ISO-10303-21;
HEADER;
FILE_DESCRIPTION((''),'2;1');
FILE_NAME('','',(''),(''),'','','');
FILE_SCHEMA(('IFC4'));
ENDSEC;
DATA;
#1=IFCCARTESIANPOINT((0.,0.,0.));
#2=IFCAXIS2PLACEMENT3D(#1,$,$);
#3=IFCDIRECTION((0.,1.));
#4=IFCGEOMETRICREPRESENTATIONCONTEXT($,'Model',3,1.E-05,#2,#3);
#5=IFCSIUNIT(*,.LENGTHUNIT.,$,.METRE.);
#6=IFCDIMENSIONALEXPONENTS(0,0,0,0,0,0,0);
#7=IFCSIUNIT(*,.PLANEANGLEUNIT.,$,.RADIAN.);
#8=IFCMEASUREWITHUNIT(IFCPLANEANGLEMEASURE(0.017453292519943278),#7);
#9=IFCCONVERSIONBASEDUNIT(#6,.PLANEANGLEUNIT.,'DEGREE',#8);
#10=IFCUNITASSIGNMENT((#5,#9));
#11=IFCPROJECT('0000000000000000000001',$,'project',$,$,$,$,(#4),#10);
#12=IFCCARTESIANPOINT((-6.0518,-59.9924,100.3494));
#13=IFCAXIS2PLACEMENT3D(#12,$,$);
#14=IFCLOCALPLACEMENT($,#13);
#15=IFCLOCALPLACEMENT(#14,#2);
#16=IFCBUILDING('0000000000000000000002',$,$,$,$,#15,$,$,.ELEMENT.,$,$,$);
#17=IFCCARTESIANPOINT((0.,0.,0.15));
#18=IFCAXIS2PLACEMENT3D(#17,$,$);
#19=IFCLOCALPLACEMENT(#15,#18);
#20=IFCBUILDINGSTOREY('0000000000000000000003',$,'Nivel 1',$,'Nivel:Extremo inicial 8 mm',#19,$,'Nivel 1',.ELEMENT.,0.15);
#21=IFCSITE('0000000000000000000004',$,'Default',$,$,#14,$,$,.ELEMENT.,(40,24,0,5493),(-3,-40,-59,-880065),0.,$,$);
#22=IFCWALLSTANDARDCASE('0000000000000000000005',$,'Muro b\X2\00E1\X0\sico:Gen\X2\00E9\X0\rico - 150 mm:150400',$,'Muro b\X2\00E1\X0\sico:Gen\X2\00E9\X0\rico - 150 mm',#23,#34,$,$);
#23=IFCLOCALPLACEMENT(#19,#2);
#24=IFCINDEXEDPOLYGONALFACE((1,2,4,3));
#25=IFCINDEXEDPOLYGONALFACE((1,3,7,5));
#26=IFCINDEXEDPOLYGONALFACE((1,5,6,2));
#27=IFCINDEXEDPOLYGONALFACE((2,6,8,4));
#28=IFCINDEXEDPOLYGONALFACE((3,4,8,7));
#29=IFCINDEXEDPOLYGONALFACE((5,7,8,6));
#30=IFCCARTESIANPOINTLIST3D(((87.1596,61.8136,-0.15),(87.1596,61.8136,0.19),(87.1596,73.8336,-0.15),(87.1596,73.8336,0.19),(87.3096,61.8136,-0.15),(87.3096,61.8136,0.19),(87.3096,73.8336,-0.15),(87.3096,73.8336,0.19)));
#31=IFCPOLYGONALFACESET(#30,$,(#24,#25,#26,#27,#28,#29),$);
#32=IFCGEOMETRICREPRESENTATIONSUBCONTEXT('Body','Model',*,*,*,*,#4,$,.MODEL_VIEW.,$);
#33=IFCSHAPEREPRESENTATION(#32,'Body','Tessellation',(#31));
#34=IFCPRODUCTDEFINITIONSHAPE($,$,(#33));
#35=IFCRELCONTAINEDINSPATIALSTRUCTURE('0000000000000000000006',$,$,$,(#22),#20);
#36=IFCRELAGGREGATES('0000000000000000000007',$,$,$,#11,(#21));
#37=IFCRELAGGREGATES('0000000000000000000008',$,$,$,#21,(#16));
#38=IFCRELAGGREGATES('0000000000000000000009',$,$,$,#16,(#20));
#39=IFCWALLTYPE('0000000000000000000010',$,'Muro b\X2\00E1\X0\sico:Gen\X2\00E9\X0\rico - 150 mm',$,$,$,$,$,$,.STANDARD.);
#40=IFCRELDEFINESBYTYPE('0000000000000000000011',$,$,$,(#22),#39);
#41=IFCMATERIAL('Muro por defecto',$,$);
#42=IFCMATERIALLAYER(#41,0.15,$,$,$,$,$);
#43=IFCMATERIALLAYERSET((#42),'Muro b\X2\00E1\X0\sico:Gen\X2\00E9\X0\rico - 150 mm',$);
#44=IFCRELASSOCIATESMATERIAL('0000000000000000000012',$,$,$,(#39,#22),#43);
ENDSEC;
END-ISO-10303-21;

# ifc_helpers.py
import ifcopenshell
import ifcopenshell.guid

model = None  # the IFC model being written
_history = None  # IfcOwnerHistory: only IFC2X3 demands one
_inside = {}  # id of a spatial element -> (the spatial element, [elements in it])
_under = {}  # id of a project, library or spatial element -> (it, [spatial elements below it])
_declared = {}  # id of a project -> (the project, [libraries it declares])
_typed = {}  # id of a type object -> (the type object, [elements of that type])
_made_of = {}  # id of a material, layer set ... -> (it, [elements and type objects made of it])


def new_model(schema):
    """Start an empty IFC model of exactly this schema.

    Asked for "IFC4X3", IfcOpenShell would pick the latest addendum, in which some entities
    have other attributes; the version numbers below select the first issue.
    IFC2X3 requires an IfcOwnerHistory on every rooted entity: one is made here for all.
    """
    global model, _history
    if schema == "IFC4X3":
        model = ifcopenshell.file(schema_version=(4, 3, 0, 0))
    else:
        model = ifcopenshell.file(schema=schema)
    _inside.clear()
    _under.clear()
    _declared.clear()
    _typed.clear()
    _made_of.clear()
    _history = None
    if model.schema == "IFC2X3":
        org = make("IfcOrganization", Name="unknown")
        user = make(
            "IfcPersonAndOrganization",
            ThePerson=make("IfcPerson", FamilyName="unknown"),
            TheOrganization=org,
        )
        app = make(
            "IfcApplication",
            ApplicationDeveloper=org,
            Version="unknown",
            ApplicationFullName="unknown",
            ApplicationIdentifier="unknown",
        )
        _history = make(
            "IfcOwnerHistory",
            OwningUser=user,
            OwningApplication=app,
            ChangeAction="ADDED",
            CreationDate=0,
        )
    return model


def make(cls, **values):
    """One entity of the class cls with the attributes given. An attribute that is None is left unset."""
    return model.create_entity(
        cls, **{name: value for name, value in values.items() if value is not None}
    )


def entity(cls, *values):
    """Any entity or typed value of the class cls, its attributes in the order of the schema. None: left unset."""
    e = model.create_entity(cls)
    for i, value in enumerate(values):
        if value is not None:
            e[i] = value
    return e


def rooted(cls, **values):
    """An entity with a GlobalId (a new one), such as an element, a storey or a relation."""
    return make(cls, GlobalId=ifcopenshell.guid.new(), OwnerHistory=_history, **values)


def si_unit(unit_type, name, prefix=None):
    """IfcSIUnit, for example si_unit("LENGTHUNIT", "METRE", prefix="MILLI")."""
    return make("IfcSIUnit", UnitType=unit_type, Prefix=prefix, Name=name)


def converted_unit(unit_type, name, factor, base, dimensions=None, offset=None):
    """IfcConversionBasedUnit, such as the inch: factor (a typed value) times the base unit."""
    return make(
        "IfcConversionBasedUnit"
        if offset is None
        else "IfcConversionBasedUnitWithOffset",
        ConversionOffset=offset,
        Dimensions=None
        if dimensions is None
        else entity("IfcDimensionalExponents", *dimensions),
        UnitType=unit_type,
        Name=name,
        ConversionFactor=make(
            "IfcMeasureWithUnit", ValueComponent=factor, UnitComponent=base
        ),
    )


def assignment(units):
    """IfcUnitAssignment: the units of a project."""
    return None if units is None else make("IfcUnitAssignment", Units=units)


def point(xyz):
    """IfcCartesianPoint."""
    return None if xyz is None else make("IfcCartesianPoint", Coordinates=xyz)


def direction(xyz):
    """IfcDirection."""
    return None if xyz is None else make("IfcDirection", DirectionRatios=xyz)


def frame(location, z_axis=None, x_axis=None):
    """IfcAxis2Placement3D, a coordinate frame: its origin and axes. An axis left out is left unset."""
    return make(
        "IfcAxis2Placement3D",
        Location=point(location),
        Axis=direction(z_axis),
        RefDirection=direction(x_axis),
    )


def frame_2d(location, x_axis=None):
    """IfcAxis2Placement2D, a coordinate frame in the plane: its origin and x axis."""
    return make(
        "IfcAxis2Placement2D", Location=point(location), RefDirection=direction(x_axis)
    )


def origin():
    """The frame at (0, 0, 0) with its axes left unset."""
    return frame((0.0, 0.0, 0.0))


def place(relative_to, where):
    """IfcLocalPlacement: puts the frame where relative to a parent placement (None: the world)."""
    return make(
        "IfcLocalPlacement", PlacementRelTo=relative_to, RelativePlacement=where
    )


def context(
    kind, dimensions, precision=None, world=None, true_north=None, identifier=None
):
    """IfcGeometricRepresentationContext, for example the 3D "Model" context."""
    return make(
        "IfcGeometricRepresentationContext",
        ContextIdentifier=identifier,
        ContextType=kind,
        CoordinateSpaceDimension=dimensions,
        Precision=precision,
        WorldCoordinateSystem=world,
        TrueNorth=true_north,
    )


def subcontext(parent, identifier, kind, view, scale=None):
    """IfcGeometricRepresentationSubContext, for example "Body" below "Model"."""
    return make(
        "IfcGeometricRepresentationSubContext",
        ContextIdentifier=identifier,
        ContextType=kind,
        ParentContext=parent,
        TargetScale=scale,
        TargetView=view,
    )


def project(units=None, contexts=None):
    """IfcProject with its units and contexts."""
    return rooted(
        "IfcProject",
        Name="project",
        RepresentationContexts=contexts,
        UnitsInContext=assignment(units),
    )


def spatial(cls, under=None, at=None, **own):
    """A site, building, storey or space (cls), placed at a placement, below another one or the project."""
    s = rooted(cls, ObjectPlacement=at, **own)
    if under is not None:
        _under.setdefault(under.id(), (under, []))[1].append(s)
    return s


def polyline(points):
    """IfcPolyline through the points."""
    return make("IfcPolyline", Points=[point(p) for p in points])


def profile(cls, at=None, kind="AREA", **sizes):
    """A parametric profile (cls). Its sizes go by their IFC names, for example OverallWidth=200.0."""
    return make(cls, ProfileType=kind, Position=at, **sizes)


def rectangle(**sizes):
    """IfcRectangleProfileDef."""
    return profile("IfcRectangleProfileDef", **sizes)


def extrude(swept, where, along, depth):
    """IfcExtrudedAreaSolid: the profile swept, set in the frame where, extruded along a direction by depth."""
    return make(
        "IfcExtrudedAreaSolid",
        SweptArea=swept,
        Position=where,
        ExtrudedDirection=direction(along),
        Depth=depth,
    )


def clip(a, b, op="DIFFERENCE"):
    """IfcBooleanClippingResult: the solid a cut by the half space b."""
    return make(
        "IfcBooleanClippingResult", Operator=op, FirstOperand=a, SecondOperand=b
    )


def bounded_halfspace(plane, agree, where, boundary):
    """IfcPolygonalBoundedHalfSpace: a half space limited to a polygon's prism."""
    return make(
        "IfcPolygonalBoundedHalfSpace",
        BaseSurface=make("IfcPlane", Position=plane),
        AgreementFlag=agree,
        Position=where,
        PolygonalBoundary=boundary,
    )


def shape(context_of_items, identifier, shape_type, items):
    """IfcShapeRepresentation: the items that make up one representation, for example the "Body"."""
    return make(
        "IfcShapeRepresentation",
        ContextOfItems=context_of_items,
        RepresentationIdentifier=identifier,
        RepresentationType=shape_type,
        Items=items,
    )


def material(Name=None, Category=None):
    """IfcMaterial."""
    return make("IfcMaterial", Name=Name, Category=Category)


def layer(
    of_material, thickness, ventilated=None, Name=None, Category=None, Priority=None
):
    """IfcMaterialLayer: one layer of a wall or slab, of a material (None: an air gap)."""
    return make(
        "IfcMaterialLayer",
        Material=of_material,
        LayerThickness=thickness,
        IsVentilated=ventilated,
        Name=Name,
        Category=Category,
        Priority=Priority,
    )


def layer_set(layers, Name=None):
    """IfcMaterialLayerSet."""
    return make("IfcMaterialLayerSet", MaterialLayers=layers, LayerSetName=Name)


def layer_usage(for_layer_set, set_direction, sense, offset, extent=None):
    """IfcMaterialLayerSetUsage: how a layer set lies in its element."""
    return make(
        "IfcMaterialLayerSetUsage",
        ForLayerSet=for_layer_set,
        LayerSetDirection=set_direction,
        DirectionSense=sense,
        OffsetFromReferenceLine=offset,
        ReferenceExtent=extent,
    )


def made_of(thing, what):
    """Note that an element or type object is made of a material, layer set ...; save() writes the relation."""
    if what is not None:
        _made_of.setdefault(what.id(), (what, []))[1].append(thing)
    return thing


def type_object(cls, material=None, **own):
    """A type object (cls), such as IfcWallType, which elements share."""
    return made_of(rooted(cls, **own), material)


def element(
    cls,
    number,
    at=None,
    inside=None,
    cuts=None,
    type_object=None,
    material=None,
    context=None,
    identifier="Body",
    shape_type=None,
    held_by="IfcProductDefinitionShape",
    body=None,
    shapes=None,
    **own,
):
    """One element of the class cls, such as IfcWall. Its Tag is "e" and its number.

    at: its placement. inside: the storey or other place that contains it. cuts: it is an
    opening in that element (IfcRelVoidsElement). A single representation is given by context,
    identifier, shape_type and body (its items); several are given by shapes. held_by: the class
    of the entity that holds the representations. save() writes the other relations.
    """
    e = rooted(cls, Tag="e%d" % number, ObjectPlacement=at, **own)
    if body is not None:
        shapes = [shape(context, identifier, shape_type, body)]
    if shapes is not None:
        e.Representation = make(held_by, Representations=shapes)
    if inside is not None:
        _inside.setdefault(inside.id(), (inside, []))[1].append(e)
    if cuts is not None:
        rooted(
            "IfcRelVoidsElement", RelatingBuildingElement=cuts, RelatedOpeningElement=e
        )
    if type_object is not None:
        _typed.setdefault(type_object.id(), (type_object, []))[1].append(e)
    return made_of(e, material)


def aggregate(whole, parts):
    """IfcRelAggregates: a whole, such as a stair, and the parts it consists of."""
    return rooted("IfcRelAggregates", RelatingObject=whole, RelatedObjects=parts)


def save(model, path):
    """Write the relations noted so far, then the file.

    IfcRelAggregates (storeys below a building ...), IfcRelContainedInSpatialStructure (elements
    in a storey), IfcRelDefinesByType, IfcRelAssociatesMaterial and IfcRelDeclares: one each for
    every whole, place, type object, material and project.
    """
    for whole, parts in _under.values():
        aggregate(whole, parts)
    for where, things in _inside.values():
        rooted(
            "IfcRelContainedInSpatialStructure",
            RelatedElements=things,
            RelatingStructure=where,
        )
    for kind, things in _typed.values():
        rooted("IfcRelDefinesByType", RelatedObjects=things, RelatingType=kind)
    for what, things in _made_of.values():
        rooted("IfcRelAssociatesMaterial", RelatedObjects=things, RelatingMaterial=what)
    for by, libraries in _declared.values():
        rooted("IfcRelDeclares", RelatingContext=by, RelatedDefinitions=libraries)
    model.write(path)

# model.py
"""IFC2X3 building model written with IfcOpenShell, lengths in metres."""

from ifc_helpers import new_model, entity, si_unit, converted_unit, direction, frame, frame_2d, origin, place, context, subcontext, project, spatial, polyline, rectangle, extrude, clip, bounded_halfspace, material, layer, layer_set, layer_usage, type_object, element, save


model = new_model("IFC2X3")

# Units and contexts
model_context = context("Model", 3, precision=1e-05, world=origin(), true_north=direction((0.0, 1.0)))
body_context = subcontext(model_context, "Body", "Model", "MODEL_VIEW")
ifc_project = project(units=[si_unit("LENGTHUNIT", "METRE"), converted_unit("PLANEANGLEUNIT", "DEGREE", entity("IfcPlaneAngleMeasure", 0.017453292519943278), si_unit("PLANEANGLEUNIT", "RADIAN"), dimensions=[0, 0, 0, 0, 0, 0, 0])], contexts=[model_context])

# Site, building, storey
site_placement = place(None, frame((-6.0518, -59.9924, 100.3494)))
site = spatial("IfcSite", under=ifc_project, at=site_placement, Name="Default", CompositionType="ELEMENT", RefLatitude=(40, 24, 0, 5493), RefLongitude=(-3, -40, -59, -880065), RefElevation=0.0)
building_placement = place(site_placement, origin())
building = spatial("IfcBuilding", under=site, at=building_placement, CompositionType="ELEMENT")
storey_placement = place(building_placement, frame((0.0, 0.0, 0.15)))
storey = spatial("IfcBuildingStorey", under=building, at=storey_placement, Name="Nivel 1", ObjectType="Nivel:Extremo inicial 8 mm", LongName="Nivel 1", CompositionType="ELEMENT", Elevation=0.15)

# Wall
ifc_material_1 = material(Name="Muro por defecto")
ifc_layer = layer(ifc_material_1, 0.15)
ifc_layer_set = layer_set([ifc_layer], Name="Muro básico:Genérico - 150 mm")
ifc_layer_usage = layer_usage(ifc_layer_set, "AXIS2", "POSITIVE", -0.075)
wall_type = type_object("IfcWallType", Name="Muro básico:Genérico - 150 mm", PredefinedType="STANDARD", material=ifc_layer_set)
wall_placement = place(storey_placement, frame((87.2346, 73.8336, -0.15), z_axis=(0.0, 0.0, 1.0), x_axis=(0.0, -1.0, 0.0)))
element("IfcWallStandardCase", 1, at=wall_placement, inside=storey, type_object=wall_type, material=ifc_layer_usage, Name="Muro básico:Genérico - 150 mm:150400", ObjectType="Muro básico:Genérico - 150 mm", context=body_context, shape_type="Clipping", body=[
    clip(extrude(rectangle(XDim=12.02, YDim=0.15, at=frame_2d((6.01, 0.0), x_axis=(-1.0, 0.0))), origin(), (0.0, 0.0, 1.0), 0.34), bounded_halfspace(frame((0.0, -0.075, 0.34), z_axis=(0.0, 0.0, -1.0), x_axis=(1.0, 0.0, 0.0)), True, frame((0.0, -0.075, 0.34), z_axis=(0.0, 0.0, -1.0), x_axis=(1.0, 0.0, 0.0)), polyline([(0.0, 0.0), (0.0, -0.15), (12.02, -0.15), (12.02, 0.0), (0.0, 0.0)]))),
])

save(model, "model.ifc")
